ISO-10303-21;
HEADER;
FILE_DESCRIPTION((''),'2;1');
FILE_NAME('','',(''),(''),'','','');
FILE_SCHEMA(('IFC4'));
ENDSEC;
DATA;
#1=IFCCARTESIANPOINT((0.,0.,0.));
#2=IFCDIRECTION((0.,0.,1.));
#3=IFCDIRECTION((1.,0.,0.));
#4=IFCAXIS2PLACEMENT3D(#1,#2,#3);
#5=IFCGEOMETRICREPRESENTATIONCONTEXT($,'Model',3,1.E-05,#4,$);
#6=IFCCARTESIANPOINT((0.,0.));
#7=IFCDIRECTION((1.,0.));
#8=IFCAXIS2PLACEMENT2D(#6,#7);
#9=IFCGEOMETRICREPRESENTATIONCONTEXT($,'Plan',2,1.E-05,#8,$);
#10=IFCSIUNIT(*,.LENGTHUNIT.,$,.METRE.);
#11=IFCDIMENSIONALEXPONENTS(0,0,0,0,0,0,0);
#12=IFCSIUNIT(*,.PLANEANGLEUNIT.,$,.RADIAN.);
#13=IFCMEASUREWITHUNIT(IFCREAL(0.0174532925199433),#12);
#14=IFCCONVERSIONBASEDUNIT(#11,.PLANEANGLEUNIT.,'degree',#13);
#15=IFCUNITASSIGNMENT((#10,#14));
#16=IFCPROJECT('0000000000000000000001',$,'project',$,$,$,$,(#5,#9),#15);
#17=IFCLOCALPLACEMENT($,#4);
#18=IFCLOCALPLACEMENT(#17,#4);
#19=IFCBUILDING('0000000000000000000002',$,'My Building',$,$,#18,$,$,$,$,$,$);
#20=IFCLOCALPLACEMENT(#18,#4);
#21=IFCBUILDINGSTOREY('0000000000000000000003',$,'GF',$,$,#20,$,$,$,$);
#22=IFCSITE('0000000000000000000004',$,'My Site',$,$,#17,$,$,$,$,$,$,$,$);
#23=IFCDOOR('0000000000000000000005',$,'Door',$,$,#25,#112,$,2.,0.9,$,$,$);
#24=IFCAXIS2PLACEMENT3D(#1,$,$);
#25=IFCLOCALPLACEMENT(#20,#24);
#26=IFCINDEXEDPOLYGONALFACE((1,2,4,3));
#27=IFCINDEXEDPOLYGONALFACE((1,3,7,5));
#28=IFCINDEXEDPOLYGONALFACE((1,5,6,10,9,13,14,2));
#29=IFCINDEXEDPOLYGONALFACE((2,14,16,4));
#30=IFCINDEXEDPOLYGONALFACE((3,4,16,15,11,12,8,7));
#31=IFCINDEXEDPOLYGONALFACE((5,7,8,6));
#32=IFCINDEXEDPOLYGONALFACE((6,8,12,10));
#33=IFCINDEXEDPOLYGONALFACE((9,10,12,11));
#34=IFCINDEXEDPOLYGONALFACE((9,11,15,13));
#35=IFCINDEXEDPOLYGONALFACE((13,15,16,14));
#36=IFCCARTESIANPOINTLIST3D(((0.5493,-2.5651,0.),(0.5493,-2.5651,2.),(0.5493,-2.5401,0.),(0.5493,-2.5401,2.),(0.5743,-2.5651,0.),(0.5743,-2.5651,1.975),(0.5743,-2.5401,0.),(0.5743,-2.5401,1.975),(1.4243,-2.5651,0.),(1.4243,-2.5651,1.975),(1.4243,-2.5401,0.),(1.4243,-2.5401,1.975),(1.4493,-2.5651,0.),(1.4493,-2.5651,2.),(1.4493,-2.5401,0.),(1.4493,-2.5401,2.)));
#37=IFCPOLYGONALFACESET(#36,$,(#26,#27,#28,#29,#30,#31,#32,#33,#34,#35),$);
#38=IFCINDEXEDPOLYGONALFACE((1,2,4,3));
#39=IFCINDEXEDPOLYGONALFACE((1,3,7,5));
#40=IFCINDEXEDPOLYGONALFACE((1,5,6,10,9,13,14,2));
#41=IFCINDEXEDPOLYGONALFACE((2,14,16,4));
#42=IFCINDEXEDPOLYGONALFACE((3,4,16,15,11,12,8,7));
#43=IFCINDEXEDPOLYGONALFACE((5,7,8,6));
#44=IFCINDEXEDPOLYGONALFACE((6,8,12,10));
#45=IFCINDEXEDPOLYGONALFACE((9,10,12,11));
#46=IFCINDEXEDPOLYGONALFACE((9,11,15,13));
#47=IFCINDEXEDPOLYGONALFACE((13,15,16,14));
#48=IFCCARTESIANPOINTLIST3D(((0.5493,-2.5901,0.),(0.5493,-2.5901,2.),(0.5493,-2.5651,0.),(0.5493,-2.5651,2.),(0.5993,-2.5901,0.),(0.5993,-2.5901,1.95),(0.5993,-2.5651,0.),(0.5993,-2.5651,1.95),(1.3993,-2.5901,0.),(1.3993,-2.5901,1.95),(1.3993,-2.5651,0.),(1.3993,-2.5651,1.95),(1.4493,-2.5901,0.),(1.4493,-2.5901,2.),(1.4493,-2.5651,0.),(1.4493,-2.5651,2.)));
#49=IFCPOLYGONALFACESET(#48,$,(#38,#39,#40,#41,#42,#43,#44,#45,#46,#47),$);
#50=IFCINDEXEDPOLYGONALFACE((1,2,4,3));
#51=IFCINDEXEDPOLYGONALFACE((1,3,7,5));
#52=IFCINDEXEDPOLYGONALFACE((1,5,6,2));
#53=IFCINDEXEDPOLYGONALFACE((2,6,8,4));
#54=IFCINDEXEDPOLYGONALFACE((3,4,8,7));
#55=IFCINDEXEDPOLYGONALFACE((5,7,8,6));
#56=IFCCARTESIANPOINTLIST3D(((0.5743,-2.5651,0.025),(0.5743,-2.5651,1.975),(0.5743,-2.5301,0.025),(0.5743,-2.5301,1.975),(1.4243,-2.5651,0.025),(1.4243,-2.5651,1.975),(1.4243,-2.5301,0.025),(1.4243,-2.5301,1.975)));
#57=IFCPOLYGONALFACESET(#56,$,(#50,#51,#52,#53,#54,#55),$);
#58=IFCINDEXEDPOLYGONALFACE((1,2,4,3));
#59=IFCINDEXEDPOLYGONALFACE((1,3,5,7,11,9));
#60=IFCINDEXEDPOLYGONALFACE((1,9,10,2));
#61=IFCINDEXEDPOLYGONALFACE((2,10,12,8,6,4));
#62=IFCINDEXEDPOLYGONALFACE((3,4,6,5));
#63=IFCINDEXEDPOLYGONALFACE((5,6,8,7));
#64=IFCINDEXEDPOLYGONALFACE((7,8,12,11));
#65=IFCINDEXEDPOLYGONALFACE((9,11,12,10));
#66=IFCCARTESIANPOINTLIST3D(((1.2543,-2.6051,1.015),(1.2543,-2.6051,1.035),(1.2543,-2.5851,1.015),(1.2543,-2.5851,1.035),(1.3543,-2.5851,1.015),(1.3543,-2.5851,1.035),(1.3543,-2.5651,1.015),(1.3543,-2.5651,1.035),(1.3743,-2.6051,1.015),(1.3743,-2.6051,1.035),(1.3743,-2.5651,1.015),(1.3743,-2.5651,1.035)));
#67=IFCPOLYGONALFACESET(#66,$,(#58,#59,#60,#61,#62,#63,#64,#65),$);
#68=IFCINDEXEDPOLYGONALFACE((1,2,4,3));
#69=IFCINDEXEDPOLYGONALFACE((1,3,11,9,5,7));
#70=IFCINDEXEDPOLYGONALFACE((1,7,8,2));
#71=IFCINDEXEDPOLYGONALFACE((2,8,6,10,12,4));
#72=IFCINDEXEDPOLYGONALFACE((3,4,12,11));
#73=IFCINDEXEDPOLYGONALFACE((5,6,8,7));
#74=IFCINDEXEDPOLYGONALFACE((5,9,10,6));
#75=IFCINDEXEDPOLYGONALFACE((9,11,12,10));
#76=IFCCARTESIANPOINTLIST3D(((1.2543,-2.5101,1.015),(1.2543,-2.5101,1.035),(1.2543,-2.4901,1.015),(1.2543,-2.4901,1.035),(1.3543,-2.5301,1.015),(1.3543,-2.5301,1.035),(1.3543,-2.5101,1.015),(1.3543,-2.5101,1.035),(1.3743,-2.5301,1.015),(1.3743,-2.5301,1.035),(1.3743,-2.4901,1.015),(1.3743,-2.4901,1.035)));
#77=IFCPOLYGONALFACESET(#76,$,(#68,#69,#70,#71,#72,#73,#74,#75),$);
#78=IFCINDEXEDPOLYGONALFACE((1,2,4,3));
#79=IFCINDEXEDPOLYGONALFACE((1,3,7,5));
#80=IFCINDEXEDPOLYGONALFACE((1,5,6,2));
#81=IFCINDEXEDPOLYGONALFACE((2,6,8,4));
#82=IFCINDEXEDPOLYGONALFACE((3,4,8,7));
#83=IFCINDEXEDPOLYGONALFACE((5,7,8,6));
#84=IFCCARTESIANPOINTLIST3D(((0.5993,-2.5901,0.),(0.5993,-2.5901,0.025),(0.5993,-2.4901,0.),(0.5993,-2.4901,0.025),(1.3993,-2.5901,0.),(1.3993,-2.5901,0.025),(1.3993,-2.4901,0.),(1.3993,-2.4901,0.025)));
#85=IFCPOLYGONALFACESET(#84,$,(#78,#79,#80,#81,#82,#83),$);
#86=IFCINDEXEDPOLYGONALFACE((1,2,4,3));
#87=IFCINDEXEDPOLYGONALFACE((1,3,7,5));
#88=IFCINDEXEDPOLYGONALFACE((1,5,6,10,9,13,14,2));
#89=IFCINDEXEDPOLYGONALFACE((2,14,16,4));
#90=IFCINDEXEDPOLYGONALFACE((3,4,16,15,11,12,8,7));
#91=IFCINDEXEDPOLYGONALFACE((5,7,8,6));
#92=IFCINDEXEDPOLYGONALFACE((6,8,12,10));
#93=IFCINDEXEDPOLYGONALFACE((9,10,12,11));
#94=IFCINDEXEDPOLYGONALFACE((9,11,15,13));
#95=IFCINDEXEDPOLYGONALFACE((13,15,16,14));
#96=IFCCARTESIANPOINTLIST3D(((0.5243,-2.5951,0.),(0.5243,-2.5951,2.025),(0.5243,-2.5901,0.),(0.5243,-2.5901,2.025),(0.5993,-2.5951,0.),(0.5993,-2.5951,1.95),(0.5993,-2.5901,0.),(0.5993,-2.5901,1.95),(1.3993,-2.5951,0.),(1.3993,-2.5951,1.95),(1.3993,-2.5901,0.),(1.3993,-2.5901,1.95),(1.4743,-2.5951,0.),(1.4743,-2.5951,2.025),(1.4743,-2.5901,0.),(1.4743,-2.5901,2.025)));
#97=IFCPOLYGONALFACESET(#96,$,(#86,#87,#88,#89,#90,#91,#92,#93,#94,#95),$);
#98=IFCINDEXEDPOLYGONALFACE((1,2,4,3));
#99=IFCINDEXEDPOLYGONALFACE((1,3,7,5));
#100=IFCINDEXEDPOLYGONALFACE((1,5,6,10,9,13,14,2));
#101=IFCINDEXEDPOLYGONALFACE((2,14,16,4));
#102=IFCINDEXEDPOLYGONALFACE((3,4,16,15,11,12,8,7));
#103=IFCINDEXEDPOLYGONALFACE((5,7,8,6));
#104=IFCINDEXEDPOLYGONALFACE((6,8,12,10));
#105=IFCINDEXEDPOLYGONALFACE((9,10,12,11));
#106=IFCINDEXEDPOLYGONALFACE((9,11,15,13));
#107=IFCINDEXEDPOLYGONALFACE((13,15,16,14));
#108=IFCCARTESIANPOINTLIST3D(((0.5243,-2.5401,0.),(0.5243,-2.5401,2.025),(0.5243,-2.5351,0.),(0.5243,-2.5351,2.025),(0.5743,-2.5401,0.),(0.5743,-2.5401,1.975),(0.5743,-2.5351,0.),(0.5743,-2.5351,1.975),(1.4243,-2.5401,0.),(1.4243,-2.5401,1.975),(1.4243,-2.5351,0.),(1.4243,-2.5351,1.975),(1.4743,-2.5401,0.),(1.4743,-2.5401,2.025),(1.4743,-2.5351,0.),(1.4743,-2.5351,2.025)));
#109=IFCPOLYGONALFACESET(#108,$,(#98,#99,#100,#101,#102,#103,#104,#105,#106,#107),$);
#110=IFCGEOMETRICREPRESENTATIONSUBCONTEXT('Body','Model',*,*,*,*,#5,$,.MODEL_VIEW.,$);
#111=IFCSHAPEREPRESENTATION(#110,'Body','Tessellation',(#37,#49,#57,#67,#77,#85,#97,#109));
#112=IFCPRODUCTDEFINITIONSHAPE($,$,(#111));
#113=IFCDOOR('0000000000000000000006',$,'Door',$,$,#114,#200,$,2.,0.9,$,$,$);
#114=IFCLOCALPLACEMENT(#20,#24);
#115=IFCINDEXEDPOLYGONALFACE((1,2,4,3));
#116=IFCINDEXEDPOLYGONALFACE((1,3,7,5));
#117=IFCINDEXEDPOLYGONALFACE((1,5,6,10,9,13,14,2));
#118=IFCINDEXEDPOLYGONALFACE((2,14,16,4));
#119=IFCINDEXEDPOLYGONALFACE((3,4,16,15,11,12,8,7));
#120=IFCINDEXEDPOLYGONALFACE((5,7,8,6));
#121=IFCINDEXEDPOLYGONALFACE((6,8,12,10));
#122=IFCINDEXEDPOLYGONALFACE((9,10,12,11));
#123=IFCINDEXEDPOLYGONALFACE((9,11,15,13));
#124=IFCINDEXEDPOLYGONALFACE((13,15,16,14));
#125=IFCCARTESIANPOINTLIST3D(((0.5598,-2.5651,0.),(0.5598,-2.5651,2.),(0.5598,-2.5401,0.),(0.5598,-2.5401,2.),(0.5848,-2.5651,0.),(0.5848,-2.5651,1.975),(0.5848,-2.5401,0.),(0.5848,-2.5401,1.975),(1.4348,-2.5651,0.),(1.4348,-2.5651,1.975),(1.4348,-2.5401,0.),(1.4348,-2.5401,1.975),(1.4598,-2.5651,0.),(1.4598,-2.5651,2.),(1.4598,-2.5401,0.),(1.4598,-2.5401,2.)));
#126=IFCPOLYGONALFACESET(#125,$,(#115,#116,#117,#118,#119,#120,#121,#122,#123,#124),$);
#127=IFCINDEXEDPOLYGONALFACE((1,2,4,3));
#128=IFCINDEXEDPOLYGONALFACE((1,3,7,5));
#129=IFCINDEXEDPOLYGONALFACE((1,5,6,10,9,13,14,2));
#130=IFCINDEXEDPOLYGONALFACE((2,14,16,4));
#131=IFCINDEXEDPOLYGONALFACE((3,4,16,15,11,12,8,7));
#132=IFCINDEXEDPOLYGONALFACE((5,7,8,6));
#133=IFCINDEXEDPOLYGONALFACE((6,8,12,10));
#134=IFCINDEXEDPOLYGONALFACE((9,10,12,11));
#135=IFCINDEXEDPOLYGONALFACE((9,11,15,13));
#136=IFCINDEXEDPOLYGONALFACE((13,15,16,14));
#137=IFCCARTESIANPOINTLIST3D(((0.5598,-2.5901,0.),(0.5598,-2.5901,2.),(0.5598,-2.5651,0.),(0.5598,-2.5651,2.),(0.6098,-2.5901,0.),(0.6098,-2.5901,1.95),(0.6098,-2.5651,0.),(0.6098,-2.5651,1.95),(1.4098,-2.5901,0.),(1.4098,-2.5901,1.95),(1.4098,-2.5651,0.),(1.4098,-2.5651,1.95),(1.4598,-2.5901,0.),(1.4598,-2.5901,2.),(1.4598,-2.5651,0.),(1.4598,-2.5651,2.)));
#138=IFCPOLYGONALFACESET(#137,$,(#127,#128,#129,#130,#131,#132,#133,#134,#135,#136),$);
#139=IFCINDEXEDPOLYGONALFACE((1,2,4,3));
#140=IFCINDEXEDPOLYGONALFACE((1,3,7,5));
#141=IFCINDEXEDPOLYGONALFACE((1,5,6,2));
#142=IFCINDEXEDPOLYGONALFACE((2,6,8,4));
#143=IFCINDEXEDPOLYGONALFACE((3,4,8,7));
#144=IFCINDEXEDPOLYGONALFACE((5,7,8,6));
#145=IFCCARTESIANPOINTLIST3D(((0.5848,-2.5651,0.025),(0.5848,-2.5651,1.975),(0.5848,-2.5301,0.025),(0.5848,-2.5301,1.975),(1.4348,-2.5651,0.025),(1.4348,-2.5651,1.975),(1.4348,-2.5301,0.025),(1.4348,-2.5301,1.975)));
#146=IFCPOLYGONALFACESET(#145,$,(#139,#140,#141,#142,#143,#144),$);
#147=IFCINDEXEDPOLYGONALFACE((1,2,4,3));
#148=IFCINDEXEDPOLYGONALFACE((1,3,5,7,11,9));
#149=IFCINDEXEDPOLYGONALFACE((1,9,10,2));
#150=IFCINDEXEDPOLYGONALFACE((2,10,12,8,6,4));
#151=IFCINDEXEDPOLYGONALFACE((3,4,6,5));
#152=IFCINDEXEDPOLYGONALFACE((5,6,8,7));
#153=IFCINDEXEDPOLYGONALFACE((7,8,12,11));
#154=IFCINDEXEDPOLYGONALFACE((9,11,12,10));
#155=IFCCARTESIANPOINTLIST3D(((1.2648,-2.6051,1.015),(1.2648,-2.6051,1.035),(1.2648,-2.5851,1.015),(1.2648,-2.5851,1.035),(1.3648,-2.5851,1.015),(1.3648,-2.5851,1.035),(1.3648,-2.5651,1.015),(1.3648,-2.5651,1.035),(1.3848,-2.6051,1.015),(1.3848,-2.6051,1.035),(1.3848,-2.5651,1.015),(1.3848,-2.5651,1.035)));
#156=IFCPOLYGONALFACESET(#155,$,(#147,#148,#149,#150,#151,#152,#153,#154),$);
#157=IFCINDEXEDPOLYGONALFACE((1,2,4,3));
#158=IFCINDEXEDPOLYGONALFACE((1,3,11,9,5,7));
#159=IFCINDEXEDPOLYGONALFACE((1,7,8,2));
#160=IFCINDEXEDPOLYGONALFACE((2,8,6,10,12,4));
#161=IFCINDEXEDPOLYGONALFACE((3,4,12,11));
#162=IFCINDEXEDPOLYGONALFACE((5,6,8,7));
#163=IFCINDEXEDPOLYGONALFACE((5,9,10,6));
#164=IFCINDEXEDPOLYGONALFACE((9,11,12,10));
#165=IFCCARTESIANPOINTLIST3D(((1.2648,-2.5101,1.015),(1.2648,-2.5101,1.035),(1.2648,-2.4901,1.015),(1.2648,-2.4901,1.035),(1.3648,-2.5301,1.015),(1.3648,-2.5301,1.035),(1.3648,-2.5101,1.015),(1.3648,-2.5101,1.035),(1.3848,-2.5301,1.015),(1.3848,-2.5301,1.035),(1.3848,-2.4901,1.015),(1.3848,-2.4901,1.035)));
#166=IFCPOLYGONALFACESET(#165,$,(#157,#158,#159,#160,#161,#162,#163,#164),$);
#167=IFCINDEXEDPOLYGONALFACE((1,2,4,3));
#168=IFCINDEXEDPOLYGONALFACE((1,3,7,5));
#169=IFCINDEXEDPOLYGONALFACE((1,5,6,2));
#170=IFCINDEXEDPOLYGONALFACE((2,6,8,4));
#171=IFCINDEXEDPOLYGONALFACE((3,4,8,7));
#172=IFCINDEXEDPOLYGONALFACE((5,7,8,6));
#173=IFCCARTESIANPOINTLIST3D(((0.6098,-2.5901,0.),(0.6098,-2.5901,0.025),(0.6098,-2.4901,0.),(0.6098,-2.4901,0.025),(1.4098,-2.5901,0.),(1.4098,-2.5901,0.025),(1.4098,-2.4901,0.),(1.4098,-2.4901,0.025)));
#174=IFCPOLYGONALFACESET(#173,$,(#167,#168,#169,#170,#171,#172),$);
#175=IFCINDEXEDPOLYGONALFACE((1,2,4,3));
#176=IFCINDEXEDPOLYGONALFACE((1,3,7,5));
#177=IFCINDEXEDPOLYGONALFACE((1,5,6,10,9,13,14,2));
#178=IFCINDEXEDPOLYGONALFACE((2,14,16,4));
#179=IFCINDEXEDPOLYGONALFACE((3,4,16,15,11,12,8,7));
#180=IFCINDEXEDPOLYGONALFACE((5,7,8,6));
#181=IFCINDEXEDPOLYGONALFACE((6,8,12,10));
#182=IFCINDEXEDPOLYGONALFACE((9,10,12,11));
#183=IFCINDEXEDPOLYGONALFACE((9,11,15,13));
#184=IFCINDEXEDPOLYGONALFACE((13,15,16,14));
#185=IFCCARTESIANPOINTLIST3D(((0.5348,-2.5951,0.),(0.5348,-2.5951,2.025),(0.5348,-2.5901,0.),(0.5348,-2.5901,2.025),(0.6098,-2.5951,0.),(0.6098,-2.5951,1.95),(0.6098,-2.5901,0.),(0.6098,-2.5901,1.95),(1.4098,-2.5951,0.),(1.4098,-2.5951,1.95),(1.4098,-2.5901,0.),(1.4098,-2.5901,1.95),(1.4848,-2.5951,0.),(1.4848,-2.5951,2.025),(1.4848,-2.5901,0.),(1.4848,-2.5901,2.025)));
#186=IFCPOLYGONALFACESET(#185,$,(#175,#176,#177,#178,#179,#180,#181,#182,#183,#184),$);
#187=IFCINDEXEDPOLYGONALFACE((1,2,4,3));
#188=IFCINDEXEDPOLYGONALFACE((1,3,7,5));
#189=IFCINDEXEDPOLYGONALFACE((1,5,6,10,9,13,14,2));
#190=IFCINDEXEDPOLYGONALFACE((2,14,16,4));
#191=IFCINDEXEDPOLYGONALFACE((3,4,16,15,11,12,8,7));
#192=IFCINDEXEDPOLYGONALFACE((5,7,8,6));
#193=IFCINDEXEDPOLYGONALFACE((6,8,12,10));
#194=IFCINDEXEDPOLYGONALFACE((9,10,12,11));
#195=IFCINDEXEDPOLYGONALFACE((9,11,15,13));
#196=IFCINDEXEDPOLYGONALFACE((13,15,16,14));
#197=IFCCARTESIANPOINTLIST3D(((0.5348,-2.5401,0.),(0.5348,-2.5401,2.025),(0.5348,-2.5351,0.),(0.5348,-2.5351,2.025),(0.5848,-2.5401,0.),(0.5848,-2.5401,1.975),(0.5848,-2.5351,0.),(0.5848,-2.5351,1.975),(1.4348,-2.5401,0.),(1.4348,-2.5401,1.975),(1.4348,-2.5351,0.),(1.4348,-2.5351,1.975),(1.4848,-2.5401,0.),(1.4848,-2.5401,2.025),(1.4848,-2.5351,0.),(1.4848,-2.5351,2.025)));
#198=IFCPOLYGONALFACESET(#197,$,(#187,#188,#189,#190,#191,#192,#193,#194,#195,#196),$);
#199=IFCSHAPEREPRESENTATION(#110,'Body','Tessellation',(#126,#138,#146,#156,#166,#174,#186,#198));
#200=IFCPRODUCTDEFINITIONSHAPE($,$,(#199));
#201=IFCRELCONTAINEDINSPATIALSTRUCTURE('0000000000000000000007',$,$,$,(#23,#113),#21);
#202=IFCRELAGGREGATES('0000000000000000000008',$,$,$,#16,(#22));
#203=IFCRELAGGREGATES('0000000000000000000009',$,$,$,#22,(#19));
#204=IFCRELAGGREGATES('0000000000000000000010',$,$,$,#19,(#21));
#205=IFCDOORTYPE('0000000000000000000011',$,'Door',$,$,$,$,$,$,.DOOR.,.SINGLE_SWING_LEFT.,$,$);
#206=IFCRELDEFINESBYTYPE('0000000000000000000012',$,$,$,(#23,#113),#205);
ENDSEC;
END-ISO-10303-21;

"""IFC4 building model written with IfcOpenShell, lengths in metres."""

from ifc_helpers import new_model, entity, si_unit, converted_unit, frame, origin_with_axes, origin_2d_with_axis, place, context, subcontext, project, spatial, line, indexed_curve, outline, extrude, shape, source, transform, mapped, type_object, type_shapes, element, save


model = new_model("IFC4")

# Units and contexts
model_context = context("Model", 3, precision=1e-05, world=origin_with_axes())
plan_context = context("Plan", 2, precision=1e-05, world=origin_2d_with_axis())
body_context_1 = subcontext(model_context, "Body", "Model", "MODEL_VIEW")
body_context_2 = subcontext(plan_context, "Body", "Plan", "PLAN_VIEW")
ifc_project = project(units=[si_unit("LENGTHUNIT", "METRE"), converted_unit("PLANEANGLEUNIT", "degree", entity("IfcReal", 0.0174532925199433), si_unit("PLANEANGLEUNIT", "RADIAN"), dimensions=[0, 0, 0, 0, 0, 0, 0])], contexts=[model_context, plan_context])

# Site, building, storey
site_placement = place(None, origin_with_axes())
site = spatial("IfcSite", under=ifc_project, at=site_placement, Name="My Site")
building_placement = place(site_placement, origin_with_axes())
building = spatial("IfcBuilding", under=site, at=building_placement, Name="My Building")
storey_placement = place(building_placement, origin_with_axes())
storey = spatial("IfcBuildingStorey", under=building, at=storey_placement, Name="GF")

# Shared definitions
door_type = type_object("IfcDoorType", Name="Door", OperationType="SINGLE_SWING_LEFT", PredefinedType="DOOR")
shared_shape_1 = source(origin_with_axes(), body_context_1, "Body", "SweptSolid", [
    extrude(outline(indexed_curve([(0.0, 0.0), (0.0, 2.0), (0.9, 2.0), (0.9, 0.0), (0.875, 0.0), (0.875, 1.975), (0.025, 1.975), (0.025, 0.0)], segments=[line(1, 2, 3, 4, 5, 6, 7, 8, 1)])), frame((0.0, 0.025, 0.0), z_axis=(0.0, -1.0, 0.0), x_axis=(1.0, 0.0, 0.0)), (0.0, 0.0, -1.0), 0.025),
    extrude(outline(indexed_curve([(0.0, 0.0), (0.0, 2.0), (0.9, 2.0), (0.9, 0.0), (0.85, 0.0), (0.85, 1.95), (0.05, 1.95), (0.05, 0.0)], segments=[line(1, 2, 3, 4, 5, 6, 7, 8, 1)])), frame((0.0, 0.0, 0.0), z_axis=(0.0, -1.0, 0.0), x_axis=(1.0, 0.0, 0.0)), (0.0, 0.0, -1.0), 0.025),
    extrude(outline(indexed_curve([(0.0, 0.0), (0.85, 0.0), (0.85, 0.035), (0.0, 0.035)], segments=[line(1, 2, 3, 4, 1)])), frame((0.025, 0.025, 0.025), z_axis=(0.0, 0.0, 1.0), x_axis=(1.0, 0.0, 0.0)), (0.0, 0.0, 1.0), 1.95),
    extrude(outline(indexed_curve([(0.0, 0.0), (0.0, -0.04), (-0.12, -0.04), (-0.12, -0.02), (-0.02, -0.02), (-0.02, 0.0)], segments=[line(1, 2, 3, 4, 5, 6, 1)])), frame((0.825, 0.025, 1.015), z_axis=(0.0, 0.0, 1.0), x_axis=(1.0, 0.0, 0.0)), (0.0, 0.0, 1.0), 0.02),
    extrude(outline(indexed_curve([(0.0, 0.0), (0.0, 0.04), (-0.12, 0.04), (-0.12, 0.02), (-0.02, 0.02), (-0.02, 0.0)], segments=[line(1, 2, 3, 4, 5, 6, 1)])), frame((0.825, 0.06, 1.015), z_axis=(0.0, 0.0, 1.0), x_axis=(1.0, 0.0, 0.0)), (0.0, 0.0, 1.0), 0.02),
    extrude(outline(indexed_curve([(0.0, 0.0), (0.8, 0.0), (0.8, 0.1), (0.0, 0.1)], segments=[line(1, 2, 3, 4, 1)])), frame((0.05, 0.0, 0.0), z_axis=(0.0, 0.0, 1.0), x_axis=(1.0, 0.0, 0.0)), (0.0, 0.0, 1.0), 0.025),
    extrude(outline(indexed_curve([(0.0, 0.0), (0.0, 2.025), (0.95, 2.025), (0.95, 0.0), (0.875, 0.0), (0.875, 1.95), (0.075, 1.95), (0.075, 0.0)], segments=[line(1, 2, 3, 4, 5, 6, 7, 8, 1)])), frame((-0.025, -0.005, 0.0), z_axis=(0.0, -1.0, 0.0), x_axis=(1.0, 0.0, 0.0)), (0.0, 0.0, -1.0), 0.005),
    extrude(outline(indexed_curve([(0.0, 0.0), (0.0, 2.025), (0.95, 2.025), (0.95, 0.0), (0.9, 0.0), (0.9, 1.975), (0.05, 1.975), (0.05, 0.0)], segments=[line(1, 2, 3, 4, 5, 6, 7, 8, 1)])), frame((-0.025, 0.05, 0.0), z_axis=(0.0, -1.0, 0.0), x_axis=(1.0, 0.0, 0.0)), (0.0, 0.0, -1.0), 0.005),
])
shared_shape_2 = source(origin_with_axes(), body_context_2, "Body", "Curve2D", [
    entity("IfcIndexedPolyCurve", entity("IfcCartesianPointList2D", [[0.0, 0.0], [0.0, 0.05], [0.025, 0.05], [0.025, 0.025], [0.05, 0.025], [0.05, 0.0]]), [entity("IfcLineIndex", [1, 2, 3, 4, 5, 6, 1])]),
    entity("IfcIndexedPolyCurve", entity("IfcCartesianPointList2D", [[0.9, 0.0], [0.9, 0.05], [0.875, 0.05], [0.875, 0.025], [0.85, 0.025], [0.85, 0.0]]), [entity("IfcLineIndex", [1, 2, 3, 4, 5, 6, 1])]),
    entity("IfcTrimmedCurve", entity("IfcEllipse", entity("IfcAxis2Placement2D", entity("IfcCartesianPoint", [0.06, 0.05]), entity("IfcDirection", [1.0, 0.0])), 0.815, 0.85), [entity("IfcCartesianPoint", [0.875, 0.05])], [entity("IfcCartesianPoint", [0.06, 0.9])], True, "CARTESIAN"),
    entity("IfcIndexedPolyCurve", entity("IfcCartesianPointList2D", [[0.025, 0.05], [0.06, 0.05], [0.06, 0.9], [0.025, 0.9]]), [entity("IfcLineIndex", [1, 2, 3, 4, 1])]),
])
type_shapes(door_type, [shared_shape_1, shared_shape_2])

# Doors
door_1_placement = place(storey_placement, frame((0.5493, -2.5901, 0.0), z_axis=(0.0, 0.0, 1.0), x_axis=(1.0, 0.0, 0.0)))
element("IfcDoor", 1, at=door_1_placement, inside=storey, type_object=door_type, Name="Door", OverallHeight=2.0, OverallWidth=0.9, shapes=[
    shape(body_context_1, "Body", "MappedRepresentation", [mapped(shared_shape_1, transform((0.0, 0.0, 0.0), x_axis=(1.0, 0.0, 0.0), y_axis=(0.0, 1.0, 0.0), z_axis=(0.0, 0.0, 1.0), scale=1.0))]),
    shape(body_context_2, "Body", "MappedRepresentation", [mapped(shared_shape_2, transform((0.0, 0.0, 0.0), x_axis=(1.0, 0.0, 0.0), y_axis=(0.0, 1.0, 0.0), z_axis=(0.0, 0.0, 1.0), scale=1.0))]),
])
placement_1 = place(storey_placement, frame((0.2266, -2.5901, 0.0), z_axis=(0.0, 0.0, 1.0), x_axis=(1.0, 0.0, 0.0)))
placement_2 = place(placement_1, frame((0.3332, 0.0, 0.0), z_axis=(0.0, 0.0, 1.0), x_axis=(1.0, 0.0, 0.0)))
door_2_placement = place(placement_2, origin_with_axes())
element("IfcDoor", 2, at=door_2_placement, inside=storey, type_object=door_type, Name="Door", OverallHeight=2.0, OverallWidth=0.9, shapes=[
    shape(body_context_1, "Body", "MappedRepresentation", [mapped(shared_shape_1, transform((0.0, 0.0, 0.0), x_axis=(1.0, 0.0, 0.0), y_axis=(0.0, 1.0, 0.0), z_axis=(0.0, 0.0, 1.0), scale=1.0))]),
    shape(body_context_2, "Body", "MappedRepresentation", [mapped(shared_shape_2, transform((0.0, 0.0, 0.0), x_axis=(1.0, 0.0, 0.0), y_axis=(0.0, 1.0, 0.0), z_axis=(0.0, 0.0, 1.0), scale=1.0))]),
])

save(model, "model.ifc")
